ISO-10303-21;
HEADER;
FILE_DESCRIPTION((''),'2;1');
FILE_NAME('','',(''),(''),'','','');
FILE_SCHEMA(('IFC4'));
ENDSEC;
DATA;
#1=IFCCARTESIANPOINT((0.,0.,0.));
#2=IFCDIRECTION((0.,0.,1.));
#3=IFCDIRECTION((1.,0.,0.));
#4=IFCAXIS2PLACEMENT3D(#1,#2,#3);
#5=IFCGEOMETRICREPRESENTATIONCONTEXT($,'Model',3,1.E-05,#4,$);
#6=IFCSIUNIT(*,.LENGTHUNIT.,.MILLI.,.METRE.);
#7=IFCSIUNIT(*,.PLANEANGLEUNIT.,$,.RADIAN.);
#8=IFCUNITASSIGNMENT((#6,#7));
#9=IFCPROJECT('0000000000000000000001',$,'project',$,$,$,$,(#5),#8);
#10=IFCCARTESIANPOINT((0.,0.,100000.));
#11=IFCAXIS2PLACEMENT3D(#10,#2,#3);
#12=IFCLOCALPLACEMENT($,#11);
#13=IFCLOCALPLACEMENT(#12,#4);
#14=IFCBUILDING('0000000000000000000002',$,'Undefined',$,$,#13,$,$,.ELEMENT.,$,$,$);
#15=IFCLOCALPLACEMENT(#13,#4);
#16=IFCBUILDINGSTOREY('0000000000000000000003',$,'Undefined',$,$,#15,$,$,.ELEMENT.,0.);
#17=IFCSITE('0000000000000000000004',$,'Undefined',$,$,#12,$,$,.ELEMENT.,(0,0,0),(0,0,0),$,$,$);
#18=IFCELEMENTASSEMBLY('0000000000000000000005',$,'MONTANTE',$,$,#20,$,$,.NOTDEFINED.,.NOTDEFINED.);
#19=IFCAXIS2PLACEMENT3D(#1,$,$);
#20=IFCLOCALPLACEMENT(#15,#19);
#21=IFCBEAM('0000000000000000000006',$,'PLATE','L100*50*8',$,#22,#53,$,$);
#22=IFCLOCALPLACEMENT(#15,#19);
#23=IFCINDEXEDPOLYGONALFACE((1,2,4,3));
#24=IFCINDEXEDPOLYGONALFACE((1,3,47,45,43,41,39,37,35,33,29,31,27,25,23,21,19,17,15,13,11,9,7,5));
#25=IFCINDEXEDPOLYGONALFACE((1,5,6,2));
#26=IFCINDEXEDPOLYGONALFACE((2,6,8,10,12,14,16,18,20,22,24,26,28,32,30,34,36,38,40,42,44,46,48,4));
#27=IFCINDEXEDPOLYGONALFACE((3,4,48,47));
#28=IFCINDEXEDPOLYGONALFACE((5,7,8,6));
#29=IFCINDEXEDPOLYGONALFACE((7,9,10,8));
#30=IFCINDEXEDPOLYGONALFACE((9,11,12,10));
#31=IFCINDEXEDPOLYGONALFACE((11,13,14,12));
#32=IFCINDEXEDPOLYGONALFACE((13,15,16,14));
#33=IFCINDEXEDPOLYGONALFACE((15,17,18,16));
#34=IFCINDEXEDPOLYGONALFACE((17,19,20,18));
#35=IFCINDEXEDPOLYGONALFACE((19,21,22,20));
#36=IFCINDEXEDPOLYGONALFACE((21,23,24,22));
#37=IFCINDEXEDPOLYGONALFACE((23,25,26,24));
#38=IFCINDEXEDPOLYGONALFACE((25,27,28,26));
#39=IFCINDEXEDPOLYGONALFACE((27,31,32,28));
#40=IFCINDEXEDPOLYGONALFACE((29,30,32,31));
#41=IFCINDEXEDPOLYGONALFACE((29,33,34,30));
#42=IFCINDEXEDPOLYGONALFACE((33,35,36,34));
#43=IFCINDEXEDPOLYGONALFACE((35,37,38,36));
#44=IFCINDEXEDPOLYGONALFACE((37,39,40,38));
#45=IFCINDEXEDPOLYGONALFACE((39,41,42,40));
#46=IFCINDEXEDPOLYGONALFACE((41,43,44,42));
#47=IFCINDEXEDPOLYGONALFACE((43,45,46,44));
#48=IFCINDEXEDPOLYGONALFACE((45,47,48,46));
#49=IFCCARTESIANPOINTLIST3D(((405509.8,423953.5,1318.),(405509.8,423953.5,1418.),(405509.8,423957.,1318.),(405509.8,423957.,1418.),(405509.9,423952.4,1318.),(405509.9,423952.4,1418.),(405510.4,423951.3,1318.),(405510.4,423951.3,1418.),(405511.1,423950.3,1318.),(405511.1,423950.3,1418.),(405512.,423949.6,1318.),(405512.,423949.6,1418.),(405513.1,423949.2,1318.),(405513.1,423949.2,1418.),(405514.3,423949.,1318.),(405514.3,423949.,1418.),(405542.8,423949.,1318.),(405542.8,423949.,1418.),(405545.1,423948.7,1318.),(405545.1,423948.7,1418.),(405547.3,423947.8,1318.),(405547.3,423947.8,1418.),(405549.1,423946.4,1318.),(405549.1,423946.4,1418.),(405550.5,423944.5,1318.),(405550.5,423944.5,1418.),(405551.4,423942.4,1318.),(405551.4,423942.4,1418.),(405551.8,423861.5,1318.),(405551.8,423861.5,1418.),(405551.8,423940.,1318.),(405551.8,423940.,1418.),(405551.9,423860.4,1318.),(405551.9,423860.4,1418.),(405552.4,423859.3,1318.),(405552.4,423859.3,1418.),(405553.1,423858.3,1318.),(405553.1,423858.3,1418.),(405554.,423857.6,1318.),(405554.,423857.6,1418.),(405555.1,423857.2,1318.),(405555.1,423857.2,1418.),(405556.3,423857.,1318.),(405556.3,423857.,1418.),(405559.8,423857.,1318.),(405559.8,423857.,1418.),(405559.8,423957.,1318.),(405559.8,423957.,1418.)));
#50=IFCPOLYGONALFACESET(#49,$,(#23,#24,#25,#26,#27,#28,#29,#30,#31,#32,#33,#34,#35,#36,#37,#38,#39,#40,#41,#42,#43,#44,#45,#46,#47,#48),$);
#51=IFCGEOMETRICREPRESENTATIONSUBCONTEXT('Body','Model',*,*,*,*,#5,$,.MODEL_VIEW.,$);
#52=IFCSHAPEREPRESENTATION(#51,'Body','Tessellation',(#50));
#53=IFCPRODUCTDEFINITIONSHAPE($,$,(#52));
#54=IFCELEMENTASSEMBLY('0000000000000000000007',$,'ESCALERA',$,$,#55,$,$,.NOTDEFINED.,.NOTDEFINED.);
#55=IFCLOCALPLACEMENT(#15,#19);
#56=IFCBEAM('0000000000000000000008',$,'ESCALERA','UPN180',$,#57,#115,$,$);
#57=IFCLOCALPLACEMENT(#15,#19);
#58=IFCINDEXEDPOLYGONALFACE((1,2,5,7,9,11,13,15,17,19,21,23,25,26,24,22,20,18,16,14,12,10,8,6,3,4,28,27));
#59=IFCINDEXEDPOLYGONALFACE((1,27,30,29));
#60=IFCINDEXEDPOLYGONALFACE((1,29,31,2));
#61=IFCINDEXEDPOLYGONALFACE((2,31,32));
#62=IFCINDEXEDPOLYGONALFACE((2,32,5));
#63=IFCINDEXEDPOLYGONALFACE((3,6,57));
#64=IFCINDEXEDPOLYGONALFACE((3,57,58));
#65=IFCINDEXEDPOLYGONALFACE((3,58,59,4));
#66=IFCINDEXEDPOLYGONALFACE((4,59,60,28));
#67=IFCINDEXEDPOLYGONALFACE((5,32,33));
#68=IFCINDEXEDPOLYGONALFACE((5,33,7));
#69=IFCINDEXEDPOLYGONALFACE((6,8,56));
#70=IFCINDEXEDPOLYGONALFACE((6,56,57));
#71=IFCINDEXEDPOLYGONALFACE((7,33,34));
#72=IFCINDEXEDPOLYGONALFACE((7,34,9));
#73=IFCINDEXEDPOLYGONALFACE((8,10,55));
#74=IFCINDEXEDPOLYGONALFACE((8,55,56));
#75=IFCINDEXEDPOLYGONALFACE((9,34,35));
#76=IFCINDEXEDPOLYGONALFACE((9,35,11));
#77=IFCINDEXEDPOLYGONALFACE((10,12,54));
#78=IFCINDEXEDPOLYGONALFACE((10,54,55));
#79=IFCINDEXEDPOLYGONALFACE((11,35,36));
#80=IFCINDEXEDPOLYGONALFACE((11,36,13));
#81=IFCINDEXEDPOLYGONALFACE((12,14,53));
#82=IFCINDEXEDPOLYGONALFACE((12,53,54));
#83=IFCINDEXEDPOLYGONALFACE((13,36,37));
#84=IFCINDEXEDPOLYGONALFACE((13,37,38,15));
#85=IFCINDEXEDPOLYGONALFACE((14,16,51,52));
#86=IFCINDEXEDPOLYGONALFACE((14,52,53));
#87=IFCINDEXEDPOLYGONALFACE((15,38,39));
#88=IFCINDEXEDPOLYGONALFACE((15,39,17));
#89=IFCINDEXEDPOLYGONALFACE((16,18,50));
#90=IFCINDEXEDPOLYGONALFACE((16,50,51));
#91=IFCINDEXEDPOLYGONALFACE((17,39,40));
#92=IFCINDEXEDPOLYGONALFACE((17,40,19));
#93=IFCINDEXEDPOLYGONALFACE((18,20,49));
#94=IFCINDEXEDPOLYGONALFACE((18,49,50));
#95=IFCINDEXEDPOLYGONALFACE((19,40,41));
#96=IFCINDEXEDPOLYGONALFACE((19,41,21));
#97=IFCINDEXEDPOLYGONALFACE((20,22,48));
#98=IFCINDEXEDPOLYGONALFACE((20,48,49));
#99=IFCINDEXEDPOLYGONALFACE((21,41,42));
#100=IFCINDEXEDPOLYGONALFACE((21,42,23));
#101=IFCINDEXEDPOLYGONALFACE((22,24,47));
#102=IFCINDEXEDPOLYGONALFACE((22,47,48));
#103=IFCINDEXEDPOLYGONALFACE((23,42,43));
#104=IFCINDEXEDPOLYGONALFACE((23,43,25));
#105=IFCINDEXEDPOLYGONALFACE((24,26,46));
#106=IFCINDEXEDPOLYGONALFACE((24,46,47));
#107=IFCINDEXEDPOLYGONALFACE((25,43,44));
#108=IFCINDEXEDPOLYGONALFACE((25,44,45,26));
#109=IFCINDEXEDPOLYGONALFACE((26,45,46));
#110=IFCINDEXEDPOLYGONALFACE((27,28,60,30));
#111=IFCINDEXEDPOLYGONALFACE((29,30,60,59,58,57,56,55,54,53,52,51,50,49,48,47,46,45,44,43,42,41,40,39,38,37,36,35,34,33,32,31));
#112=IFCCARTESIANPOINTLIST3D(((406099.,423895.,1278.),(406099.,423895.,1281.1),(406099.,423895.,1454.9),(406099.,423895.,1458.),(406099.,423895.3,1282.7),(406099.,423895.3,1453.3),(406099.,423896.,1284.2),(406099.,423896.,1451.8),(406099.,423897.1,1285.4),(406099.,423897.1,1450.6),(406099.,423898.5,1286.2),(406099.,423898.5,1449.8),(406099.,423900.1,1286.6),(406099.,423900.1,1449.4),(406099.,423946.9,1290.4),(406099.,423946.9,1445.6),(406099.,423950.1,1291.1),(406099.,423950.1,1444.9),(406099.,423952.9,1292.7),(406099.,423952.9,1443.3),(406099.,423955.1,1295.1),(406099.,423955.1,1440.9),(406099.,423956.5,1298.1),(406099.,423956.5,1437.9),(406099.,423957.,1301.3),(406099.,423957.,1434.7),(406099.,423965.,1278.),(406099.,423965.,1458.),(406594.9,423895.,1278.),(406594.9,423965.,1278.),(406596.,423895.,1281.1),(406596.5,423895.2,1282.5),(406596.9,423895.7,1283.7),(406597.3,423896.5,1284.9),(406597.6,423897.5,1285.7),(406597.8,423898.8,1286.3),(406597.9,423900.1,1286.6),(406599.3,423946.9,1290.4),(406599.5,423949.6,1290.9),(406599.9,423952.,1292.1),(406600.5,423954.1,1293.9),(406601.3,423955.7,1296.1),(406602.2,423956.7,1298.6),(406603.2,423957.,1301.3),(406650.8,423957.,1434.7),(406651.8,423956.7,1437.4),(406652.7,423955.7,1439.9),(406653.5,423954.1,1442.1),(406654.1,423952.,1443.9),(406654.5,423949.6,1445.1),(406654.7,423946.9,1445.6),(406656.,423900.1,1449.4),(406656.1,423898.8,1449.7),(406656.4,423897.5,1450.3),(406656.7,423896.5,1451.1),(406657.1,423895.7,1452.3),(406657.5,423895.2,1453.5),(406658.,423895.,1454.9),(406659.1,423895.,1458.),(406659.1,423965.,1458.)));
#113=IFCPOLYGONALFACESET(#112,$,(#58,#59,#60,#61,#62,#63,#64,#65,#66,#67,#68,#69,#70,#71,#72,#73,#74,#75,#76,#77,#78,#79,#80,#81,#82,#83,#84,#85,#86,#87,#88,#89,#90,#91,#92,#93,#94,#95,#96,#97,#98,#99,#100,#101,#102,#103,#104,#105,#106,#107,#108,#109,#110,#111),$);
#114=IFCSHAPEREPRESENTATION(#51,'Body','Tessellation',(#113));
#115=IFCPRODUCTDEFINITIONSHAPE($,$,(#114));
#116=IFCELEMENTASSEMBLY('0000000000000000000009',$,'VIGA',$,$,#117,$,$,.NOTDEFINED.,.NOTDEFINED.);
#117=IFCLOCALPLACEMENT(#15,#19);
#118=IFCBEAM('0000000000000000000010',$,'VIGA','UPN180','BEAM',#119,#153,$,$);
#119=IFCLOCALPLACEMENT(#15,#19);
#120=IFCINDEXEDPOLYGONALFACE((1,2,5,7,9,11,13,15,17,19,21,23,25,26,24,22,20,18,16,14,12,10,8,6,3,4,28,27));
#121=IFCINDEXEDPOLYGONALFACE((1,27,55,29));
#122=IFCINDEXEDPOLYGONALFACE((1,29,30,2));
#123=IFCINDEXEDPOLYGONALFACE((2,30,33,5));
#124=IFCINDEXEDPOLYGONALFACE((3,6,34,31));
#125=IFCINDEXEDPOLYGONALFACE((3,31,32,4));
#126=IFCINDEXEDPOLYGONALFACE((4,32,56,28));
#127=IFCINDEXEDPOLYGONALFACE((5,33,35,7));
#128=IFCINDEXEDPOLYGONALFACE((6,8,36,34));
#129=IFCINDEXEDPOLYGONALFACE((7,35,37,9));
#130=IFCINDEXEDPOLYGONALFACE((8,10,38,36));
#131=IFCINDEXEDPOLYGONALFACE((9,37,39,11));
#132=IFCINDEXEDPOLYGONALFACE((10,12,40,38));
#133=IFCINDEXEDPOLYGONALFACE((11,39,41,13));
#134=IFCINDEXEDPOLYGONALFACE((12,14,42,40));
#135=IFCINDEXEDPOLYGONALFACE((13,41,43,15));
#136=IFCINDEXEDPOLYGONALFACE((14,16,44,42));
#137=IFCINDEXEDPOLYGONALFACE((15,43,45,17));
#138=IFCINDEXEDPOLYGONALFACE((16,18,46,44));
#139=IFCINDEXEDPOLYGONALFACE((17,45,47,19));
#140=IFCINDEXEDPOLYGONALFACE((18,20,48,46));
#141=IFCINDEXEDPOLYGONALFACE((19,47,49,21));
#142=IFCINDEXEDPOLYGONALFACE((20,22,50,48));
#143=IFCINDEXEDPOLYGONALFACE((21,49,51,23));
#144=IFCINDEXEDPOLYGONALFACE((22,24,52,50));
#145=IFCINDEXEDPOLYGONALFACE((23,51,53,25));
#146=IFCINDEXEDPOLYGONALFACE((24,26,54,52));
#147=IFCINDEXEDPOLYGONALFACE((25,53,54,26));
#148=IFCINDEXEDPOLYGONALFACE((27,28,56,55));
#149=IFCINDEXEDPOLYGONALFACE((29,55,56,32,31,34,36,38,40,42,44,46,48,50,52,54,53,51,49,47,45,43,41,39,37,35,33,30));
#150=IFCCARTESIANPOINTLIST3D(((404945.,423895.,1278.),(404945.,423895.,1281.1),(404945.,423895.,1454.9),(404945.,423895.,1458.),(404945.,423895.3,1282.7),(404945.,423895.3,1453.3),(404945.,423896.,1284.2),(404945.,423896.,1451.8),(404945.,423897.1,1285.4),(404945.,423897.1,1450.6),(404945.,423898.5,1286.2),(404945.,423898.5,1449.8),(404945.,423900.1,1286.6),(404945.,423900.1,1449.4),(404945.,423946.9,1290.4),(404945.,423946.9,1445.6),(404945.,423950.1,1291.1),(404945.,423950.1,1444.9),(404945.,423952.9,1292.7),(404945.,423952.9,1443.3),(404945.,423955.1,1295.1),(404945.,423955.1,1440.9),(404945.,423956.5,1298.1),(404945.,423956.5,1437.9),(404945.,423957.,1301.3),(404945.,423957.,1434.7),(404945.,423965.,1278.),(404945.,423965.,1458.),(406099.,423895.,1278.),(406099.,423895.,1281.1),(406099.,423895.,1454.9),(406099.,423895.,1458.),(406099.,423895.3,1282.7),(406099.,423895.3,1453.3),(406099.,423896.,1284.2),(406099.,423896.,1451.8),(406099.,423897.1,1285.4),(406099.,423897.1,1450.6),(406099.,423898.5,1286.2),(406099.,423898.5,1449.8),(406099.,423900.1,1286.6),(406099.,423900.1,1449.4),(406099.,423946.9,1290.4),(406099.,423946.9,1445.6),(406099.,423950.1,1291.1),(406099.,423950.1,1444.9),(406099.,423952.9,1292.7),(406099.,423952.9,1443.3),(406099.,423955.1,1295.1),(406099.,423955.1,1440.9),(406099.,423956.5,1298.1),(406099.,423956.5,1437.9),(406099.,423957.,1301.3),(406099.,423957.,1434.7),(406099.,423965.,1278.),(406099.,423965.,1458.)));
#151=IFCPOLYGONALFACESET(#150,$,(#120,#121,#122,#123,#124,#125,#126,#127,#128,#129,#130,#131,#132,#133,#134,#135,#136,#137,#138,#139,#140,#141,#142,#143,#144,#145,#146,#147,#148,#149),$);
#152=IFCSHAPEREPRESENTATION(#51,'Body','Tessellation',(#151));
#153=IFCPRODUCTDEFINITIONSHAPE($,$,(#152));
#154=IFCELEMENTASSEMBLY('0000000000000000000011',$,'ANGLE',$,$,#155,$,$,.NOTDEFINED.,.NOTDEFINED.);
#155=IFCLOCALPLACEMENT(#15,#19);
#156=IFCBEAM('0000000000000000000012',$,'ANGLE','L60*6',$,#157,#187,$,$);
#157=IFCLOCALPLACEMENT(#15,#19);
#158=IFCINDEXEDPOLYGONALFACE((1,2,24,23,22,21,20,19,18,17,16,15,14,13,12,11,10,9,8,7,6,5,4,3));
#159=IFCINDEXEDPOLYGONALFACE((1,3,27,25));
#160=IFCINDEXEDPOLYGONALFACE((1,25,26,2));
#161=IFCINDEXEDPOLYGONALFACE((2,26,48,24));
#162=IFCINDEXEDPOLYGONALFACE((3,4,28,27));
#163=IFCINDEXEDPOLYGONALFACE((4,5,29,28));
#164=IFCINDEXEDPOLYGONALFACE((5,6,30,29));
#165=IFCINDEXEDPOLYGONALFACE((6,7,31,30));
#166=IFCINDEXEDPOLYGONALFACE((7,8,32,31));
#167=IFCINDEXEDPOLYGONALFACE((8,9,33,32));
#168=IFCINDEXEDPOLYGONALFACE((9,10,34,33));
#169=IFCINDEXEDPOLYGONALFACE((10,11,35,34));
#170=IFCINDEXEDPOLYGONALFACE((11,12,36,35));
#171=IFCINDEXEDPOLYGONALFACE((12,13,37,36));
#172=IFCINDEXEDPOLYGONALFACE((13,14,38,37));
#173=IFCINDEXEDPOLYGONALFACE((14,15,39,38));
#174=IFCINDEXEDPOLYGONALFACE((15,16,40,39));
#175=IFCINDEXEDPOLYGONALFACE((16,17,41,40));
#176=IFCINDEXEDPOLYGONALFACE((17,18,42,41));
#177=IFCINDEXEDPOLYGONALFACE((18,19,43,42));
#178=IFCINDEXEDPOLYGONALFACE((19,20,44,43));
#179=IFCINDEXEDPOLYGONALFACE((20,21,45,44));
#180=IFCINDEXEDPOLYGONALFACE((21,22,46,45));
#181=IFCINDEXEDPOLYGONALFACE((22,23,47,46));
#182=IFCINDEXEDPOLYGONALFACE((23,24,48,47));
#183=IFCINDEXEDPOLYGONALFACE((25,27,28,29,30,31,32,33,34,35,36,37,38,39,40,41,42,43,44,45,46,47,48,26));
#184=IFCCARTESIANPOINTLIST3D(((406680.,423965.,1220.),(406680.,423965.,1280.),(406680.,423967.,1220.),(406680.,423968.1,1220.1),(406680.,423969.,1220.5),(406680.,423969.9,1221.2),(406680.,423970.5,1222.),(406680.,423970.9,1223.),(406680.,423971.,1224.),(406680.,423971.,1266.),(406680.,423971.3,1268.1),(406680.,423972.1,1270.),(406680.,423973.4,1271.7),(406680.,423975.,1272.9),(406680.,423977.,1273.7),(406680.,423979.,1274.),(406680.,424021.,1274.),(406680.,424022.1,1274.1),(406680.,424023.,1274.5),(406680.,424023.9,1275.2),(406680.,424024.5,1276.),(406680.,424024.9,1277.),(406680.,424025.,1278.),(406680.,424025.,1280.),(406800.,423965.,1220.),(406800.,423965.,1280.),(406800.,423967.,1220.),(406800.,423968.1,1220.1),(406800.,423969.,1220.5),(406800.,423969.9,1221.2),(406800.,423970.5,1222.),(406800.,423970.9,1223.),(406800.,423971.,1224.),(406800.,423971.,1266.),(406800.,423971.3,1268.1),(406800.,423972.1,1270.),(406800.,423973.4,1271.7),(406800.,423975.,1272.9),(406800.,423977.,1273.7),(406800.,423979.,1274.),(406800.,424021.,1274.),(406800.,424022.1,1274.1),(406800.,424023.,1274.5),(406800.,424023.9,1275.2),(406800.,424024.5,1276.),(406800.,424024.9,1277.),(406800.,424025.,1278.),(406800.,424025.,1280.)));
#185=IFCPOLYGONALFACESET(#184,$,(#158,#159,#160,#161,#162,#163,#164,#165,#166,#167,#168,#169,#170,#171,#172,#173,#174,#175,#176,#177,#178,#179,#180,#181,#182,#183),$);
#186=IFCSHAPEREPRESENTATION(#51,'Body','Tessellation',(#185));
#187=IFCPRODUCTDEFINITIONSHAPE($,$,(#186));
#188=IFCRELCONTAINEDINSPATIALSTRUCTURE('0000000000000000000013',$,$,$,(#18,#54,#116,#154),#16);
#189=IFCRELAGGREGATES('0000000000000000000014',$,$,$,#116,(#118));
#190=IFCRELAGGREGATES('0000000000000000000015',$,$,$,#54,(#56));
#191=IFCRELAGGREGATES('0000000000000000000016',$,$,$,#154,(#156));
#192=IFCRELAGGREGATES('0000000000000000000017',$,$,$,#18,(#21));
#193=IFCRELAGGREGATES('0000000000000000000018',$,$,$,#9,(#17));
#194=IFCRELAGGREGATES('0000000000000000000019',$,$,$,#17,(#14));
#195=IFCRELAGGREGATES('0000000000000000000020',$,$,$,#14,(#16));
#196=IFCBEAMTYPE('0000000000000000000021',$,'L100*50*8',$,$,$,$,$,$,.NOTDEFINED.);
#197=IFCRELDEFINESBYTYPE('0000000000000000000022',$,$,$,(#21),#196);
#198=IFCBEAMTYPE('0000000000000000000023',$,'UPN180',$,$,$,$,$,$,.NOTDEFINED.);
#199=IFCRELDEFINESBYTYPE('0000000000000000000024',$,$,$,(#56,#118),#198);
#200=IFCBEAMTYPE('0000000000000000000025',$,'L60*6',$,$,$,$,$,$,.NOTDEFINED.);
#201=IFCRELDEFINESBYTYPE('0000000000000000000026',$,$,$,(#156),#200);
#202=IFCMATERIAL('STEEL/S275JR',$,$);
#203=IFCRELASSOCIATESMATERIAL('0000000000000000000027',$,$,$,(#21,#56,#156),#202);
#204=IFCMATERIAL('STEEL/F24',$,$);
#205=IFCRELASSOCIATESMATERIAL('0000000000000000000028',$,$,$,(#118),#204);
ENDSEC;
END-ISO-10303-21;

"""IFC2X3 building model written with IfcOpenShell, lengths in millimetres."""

from ifc_helpers import new_model, si_unit, frame, origin_with_axes, origin_2d_with_axis, place, context, subcontext, project, spatial, l_section, u_section, extrude, clip, halfspace, material, type_object, element, aggregate, save


model = new_model("IFC2X3")

# Units and contexts
model_context = context("Model", 3, precision=1e-05, world=origin_with_axes())
body_context = subcontext(model_context, "Body", "Model", "MODEL_VIEW")
ifc_project = project(units=[si_unit("LENGTHUNIT", "METRE", prefix="MILLI"), si_unit("PLANEANGLEUNIT", "RADIAN")], contexts=[model_context])

# Site, building, storey
site_placement = place(None, frame((0.0, 0.0, 100000.0), z_axis=(0.0, 0.0, 1.0), x_axis=(1.0, 0.0, 0.0)))
site = spatial("IfcSite", under=ifc_project, at=site_placement, Name="Undefined", CompositionType="ELEMENT", RefLatitude=(0, 0, 0), RefLongitude=(0, 0, 0))
building_placement = place(site_placement, origin_with_axes())
building = spatial("IfcBuilding", under=site, at=building_placement, Name="Undefined", CompositionType="ELEMENT")
storey_placement = place(building_placement, origin_with_axes())
storey = spatial("IfcBuildingStorey", under=building, at=storey_placement, Name="Undefined", CompositionType="ELEMENT", Elevation=0.0)

# Shared definitions
ifc_material_1 = material(Name="STEEL/F24")

# Element assembly
assembly_1_placement = place(storey_placement, origin_with_axes())
assembly_1 = element("IfcElementAssembly", 1, at=assembly_1_placement, inside=storey, Name="MONTANTE", AssemblyPlace="NOTDEFINED", PredefinedType="NOTDEFINED")

# Beam
ifc_material_2 = material(Name="STEEL/S275JR")
beam_type_1 = type_object("IfcBeamType", Name="L100*50*8", PredefinedType="NOTDEFINED")
beam_1_placement = place(assembly_1_placement, frame((405534.8, 423907.0, 1418.0), z_axis=(0.0, -1.0, 0.0), x_axis=(0.0, 0.0, -1.0)))
beam_1 = element("IfcBeam", 2, at=beam_1_placement, type_object=beam_type_1, material=ifc_material_2, Name="PLATE", Description="L100*50*8", context=body_context, shape_type="SweptSolid", body=[
    extrude(l_section(Depth=100.0, Width=50.0, Thickness=8.0, FilletRadius=9.0, EdgeRadius=4.5, at=origin_2d_with_axis()), frame((100.0, 0.0, 0.0), z_axis=(-1.0, 0.0, 0.0), x_axis=(0.0, -1.0, 0.0)), (0.0, 0.0, 1.0), 100.0),
])

# Element assemblies, beams
assembly_2_placement = place(storey_placement, origin_with_axes())
assembly_2 = element("IfcElementAssembly", 3, at=assembly_2_placement, inside=storey, Name="ESCALERA", AssemblyPlace="NOTDEFINED", PredefinedType="NOTDEFINED")
beam_type_2 = type_object("IfcBeamType", Name="UPN180", PredefinedType="NOTDEFINED")
beam_2_placement = place(assembly_2_placement, frame((406099.0, 423930.0, 1368.0), z_axis=(0.0, 0.0, 1.0), x_axis=(1.0, 0.0, 0.0)))
beam_2 = element("IfcBeam", 4, at=beam_2_placement, type_object=beam_type_2, material=ifc_material_2, Name="ESCALERA", Description="UPN180", context=body_context, shape_type="Clipping", body=[
    clip(extrude(u_section(Depth=180.0, FlangeWidth=70.0, WebThickness=8.0, FlangeThickness=11.0, FilletRadius=11.0, EdgeRadius=5.5, FlangeSlope=0.07983, at=origin_2d_with_axis()), frame((560.5, 0.0, 0.0), z_axis=(-1.0, 0.0, 0.0), x_axis=(0.0, -1.0, 0.0)), (0.0, 0.0, 1.0), 560.5), halfspace(frame((560.1, -35.0, 90.0), z_axis=(-0.941795, 0.0, 0.336186), x_axis=(0.0, -1.0, 0.0)), True)),
])
assembly_3_placement = place(storey_placement, origin_with_axes())
assembly_3 = element("IfcElementAssembly", 5, at=assembly_3_placement, inside=storey, Name="VIGA", AssemblyPlace="NOTDEFINED", PredefinedType="NOTDEFINED")
beam_3_placement = place(assembly_3_placement, frame((404945.0, 423930.0, 1368.0), z_axis=(0.0, 0.0, 1.0), x_axis=(1.0, 0.0, 0.0)))
beam_3 = element("IfcBeam", 6, at=beam_3_placement, type_object=beam_type_2, material=ifc_material_1, Name="VIGA", Description="UPN180", ObjectType="BEAM", context=body_context, shape_type="SweptSolid", body=[
    extrude(u_section(Depth=180.0, FlangeWidth=70.0, WebThickness=8.0, FlangeThickness=11.0, FilletRadius=11.0, EdgeRadius=5.5, FlangeSlope=0.07983, at=origin_2d_with_axis()), frame((1154.0, 0.0, 0.0), z_axis=(-1.0, 0.0, 0.0), x_axis=(0.0, -1.0, 0.0)), (0.0, 0.0, 1.0), 1154.0),
])
aggregate(assembly_3, [beam_3])
assembly_4_placement = place(storey_placement, origin_with_axes())
assembly_4 = element("IfcElementAssembly", 7, at=assembly_4_placement, inside=storey, Name="ANGLE", AssemblyPlace="NOTDEFINED", PredefinedType="NOTDEFINED")
beam_type_3 = type_object("IfcBeamType", Name="L60*6", PredefinedType="NOTDEFINED")
beam_4_placement = place(assembly_4_placement, frame((406800.0, 423995.0, 1250.0), z_axis=(0.0, 1.0, 0.0), x_axis=(-1.0, 0.0, 0.0)))
beam_4 = element("IfcBeam", 8, at=beam_4_placement, type_object=beam_type_3, material=ifc_material_2, Name="ANGLE", Description="L60*6", context=body_context, shape_type="SweptSolid", body=[
    extrude(l_section(Depth=60.0, Width=60.0, Thickness=6.0, FilletRadius=8.0, EdgeRadius=4.0, at=origin_2d_with_axis()), frame((120.0, 0.0, 0.0), z_axis=(-1.0, 0.0, 0.0), x_axis=(0.0, -1.0, 0.0)), (0.0, 0.0, 1.0), 120.0),
])

aggregate(assembly_2, [beam_2])

aggregate(assembly_4, [beam_4])

aggregate(assembly_1, [beam_1])

save(model, "model.ifc")
